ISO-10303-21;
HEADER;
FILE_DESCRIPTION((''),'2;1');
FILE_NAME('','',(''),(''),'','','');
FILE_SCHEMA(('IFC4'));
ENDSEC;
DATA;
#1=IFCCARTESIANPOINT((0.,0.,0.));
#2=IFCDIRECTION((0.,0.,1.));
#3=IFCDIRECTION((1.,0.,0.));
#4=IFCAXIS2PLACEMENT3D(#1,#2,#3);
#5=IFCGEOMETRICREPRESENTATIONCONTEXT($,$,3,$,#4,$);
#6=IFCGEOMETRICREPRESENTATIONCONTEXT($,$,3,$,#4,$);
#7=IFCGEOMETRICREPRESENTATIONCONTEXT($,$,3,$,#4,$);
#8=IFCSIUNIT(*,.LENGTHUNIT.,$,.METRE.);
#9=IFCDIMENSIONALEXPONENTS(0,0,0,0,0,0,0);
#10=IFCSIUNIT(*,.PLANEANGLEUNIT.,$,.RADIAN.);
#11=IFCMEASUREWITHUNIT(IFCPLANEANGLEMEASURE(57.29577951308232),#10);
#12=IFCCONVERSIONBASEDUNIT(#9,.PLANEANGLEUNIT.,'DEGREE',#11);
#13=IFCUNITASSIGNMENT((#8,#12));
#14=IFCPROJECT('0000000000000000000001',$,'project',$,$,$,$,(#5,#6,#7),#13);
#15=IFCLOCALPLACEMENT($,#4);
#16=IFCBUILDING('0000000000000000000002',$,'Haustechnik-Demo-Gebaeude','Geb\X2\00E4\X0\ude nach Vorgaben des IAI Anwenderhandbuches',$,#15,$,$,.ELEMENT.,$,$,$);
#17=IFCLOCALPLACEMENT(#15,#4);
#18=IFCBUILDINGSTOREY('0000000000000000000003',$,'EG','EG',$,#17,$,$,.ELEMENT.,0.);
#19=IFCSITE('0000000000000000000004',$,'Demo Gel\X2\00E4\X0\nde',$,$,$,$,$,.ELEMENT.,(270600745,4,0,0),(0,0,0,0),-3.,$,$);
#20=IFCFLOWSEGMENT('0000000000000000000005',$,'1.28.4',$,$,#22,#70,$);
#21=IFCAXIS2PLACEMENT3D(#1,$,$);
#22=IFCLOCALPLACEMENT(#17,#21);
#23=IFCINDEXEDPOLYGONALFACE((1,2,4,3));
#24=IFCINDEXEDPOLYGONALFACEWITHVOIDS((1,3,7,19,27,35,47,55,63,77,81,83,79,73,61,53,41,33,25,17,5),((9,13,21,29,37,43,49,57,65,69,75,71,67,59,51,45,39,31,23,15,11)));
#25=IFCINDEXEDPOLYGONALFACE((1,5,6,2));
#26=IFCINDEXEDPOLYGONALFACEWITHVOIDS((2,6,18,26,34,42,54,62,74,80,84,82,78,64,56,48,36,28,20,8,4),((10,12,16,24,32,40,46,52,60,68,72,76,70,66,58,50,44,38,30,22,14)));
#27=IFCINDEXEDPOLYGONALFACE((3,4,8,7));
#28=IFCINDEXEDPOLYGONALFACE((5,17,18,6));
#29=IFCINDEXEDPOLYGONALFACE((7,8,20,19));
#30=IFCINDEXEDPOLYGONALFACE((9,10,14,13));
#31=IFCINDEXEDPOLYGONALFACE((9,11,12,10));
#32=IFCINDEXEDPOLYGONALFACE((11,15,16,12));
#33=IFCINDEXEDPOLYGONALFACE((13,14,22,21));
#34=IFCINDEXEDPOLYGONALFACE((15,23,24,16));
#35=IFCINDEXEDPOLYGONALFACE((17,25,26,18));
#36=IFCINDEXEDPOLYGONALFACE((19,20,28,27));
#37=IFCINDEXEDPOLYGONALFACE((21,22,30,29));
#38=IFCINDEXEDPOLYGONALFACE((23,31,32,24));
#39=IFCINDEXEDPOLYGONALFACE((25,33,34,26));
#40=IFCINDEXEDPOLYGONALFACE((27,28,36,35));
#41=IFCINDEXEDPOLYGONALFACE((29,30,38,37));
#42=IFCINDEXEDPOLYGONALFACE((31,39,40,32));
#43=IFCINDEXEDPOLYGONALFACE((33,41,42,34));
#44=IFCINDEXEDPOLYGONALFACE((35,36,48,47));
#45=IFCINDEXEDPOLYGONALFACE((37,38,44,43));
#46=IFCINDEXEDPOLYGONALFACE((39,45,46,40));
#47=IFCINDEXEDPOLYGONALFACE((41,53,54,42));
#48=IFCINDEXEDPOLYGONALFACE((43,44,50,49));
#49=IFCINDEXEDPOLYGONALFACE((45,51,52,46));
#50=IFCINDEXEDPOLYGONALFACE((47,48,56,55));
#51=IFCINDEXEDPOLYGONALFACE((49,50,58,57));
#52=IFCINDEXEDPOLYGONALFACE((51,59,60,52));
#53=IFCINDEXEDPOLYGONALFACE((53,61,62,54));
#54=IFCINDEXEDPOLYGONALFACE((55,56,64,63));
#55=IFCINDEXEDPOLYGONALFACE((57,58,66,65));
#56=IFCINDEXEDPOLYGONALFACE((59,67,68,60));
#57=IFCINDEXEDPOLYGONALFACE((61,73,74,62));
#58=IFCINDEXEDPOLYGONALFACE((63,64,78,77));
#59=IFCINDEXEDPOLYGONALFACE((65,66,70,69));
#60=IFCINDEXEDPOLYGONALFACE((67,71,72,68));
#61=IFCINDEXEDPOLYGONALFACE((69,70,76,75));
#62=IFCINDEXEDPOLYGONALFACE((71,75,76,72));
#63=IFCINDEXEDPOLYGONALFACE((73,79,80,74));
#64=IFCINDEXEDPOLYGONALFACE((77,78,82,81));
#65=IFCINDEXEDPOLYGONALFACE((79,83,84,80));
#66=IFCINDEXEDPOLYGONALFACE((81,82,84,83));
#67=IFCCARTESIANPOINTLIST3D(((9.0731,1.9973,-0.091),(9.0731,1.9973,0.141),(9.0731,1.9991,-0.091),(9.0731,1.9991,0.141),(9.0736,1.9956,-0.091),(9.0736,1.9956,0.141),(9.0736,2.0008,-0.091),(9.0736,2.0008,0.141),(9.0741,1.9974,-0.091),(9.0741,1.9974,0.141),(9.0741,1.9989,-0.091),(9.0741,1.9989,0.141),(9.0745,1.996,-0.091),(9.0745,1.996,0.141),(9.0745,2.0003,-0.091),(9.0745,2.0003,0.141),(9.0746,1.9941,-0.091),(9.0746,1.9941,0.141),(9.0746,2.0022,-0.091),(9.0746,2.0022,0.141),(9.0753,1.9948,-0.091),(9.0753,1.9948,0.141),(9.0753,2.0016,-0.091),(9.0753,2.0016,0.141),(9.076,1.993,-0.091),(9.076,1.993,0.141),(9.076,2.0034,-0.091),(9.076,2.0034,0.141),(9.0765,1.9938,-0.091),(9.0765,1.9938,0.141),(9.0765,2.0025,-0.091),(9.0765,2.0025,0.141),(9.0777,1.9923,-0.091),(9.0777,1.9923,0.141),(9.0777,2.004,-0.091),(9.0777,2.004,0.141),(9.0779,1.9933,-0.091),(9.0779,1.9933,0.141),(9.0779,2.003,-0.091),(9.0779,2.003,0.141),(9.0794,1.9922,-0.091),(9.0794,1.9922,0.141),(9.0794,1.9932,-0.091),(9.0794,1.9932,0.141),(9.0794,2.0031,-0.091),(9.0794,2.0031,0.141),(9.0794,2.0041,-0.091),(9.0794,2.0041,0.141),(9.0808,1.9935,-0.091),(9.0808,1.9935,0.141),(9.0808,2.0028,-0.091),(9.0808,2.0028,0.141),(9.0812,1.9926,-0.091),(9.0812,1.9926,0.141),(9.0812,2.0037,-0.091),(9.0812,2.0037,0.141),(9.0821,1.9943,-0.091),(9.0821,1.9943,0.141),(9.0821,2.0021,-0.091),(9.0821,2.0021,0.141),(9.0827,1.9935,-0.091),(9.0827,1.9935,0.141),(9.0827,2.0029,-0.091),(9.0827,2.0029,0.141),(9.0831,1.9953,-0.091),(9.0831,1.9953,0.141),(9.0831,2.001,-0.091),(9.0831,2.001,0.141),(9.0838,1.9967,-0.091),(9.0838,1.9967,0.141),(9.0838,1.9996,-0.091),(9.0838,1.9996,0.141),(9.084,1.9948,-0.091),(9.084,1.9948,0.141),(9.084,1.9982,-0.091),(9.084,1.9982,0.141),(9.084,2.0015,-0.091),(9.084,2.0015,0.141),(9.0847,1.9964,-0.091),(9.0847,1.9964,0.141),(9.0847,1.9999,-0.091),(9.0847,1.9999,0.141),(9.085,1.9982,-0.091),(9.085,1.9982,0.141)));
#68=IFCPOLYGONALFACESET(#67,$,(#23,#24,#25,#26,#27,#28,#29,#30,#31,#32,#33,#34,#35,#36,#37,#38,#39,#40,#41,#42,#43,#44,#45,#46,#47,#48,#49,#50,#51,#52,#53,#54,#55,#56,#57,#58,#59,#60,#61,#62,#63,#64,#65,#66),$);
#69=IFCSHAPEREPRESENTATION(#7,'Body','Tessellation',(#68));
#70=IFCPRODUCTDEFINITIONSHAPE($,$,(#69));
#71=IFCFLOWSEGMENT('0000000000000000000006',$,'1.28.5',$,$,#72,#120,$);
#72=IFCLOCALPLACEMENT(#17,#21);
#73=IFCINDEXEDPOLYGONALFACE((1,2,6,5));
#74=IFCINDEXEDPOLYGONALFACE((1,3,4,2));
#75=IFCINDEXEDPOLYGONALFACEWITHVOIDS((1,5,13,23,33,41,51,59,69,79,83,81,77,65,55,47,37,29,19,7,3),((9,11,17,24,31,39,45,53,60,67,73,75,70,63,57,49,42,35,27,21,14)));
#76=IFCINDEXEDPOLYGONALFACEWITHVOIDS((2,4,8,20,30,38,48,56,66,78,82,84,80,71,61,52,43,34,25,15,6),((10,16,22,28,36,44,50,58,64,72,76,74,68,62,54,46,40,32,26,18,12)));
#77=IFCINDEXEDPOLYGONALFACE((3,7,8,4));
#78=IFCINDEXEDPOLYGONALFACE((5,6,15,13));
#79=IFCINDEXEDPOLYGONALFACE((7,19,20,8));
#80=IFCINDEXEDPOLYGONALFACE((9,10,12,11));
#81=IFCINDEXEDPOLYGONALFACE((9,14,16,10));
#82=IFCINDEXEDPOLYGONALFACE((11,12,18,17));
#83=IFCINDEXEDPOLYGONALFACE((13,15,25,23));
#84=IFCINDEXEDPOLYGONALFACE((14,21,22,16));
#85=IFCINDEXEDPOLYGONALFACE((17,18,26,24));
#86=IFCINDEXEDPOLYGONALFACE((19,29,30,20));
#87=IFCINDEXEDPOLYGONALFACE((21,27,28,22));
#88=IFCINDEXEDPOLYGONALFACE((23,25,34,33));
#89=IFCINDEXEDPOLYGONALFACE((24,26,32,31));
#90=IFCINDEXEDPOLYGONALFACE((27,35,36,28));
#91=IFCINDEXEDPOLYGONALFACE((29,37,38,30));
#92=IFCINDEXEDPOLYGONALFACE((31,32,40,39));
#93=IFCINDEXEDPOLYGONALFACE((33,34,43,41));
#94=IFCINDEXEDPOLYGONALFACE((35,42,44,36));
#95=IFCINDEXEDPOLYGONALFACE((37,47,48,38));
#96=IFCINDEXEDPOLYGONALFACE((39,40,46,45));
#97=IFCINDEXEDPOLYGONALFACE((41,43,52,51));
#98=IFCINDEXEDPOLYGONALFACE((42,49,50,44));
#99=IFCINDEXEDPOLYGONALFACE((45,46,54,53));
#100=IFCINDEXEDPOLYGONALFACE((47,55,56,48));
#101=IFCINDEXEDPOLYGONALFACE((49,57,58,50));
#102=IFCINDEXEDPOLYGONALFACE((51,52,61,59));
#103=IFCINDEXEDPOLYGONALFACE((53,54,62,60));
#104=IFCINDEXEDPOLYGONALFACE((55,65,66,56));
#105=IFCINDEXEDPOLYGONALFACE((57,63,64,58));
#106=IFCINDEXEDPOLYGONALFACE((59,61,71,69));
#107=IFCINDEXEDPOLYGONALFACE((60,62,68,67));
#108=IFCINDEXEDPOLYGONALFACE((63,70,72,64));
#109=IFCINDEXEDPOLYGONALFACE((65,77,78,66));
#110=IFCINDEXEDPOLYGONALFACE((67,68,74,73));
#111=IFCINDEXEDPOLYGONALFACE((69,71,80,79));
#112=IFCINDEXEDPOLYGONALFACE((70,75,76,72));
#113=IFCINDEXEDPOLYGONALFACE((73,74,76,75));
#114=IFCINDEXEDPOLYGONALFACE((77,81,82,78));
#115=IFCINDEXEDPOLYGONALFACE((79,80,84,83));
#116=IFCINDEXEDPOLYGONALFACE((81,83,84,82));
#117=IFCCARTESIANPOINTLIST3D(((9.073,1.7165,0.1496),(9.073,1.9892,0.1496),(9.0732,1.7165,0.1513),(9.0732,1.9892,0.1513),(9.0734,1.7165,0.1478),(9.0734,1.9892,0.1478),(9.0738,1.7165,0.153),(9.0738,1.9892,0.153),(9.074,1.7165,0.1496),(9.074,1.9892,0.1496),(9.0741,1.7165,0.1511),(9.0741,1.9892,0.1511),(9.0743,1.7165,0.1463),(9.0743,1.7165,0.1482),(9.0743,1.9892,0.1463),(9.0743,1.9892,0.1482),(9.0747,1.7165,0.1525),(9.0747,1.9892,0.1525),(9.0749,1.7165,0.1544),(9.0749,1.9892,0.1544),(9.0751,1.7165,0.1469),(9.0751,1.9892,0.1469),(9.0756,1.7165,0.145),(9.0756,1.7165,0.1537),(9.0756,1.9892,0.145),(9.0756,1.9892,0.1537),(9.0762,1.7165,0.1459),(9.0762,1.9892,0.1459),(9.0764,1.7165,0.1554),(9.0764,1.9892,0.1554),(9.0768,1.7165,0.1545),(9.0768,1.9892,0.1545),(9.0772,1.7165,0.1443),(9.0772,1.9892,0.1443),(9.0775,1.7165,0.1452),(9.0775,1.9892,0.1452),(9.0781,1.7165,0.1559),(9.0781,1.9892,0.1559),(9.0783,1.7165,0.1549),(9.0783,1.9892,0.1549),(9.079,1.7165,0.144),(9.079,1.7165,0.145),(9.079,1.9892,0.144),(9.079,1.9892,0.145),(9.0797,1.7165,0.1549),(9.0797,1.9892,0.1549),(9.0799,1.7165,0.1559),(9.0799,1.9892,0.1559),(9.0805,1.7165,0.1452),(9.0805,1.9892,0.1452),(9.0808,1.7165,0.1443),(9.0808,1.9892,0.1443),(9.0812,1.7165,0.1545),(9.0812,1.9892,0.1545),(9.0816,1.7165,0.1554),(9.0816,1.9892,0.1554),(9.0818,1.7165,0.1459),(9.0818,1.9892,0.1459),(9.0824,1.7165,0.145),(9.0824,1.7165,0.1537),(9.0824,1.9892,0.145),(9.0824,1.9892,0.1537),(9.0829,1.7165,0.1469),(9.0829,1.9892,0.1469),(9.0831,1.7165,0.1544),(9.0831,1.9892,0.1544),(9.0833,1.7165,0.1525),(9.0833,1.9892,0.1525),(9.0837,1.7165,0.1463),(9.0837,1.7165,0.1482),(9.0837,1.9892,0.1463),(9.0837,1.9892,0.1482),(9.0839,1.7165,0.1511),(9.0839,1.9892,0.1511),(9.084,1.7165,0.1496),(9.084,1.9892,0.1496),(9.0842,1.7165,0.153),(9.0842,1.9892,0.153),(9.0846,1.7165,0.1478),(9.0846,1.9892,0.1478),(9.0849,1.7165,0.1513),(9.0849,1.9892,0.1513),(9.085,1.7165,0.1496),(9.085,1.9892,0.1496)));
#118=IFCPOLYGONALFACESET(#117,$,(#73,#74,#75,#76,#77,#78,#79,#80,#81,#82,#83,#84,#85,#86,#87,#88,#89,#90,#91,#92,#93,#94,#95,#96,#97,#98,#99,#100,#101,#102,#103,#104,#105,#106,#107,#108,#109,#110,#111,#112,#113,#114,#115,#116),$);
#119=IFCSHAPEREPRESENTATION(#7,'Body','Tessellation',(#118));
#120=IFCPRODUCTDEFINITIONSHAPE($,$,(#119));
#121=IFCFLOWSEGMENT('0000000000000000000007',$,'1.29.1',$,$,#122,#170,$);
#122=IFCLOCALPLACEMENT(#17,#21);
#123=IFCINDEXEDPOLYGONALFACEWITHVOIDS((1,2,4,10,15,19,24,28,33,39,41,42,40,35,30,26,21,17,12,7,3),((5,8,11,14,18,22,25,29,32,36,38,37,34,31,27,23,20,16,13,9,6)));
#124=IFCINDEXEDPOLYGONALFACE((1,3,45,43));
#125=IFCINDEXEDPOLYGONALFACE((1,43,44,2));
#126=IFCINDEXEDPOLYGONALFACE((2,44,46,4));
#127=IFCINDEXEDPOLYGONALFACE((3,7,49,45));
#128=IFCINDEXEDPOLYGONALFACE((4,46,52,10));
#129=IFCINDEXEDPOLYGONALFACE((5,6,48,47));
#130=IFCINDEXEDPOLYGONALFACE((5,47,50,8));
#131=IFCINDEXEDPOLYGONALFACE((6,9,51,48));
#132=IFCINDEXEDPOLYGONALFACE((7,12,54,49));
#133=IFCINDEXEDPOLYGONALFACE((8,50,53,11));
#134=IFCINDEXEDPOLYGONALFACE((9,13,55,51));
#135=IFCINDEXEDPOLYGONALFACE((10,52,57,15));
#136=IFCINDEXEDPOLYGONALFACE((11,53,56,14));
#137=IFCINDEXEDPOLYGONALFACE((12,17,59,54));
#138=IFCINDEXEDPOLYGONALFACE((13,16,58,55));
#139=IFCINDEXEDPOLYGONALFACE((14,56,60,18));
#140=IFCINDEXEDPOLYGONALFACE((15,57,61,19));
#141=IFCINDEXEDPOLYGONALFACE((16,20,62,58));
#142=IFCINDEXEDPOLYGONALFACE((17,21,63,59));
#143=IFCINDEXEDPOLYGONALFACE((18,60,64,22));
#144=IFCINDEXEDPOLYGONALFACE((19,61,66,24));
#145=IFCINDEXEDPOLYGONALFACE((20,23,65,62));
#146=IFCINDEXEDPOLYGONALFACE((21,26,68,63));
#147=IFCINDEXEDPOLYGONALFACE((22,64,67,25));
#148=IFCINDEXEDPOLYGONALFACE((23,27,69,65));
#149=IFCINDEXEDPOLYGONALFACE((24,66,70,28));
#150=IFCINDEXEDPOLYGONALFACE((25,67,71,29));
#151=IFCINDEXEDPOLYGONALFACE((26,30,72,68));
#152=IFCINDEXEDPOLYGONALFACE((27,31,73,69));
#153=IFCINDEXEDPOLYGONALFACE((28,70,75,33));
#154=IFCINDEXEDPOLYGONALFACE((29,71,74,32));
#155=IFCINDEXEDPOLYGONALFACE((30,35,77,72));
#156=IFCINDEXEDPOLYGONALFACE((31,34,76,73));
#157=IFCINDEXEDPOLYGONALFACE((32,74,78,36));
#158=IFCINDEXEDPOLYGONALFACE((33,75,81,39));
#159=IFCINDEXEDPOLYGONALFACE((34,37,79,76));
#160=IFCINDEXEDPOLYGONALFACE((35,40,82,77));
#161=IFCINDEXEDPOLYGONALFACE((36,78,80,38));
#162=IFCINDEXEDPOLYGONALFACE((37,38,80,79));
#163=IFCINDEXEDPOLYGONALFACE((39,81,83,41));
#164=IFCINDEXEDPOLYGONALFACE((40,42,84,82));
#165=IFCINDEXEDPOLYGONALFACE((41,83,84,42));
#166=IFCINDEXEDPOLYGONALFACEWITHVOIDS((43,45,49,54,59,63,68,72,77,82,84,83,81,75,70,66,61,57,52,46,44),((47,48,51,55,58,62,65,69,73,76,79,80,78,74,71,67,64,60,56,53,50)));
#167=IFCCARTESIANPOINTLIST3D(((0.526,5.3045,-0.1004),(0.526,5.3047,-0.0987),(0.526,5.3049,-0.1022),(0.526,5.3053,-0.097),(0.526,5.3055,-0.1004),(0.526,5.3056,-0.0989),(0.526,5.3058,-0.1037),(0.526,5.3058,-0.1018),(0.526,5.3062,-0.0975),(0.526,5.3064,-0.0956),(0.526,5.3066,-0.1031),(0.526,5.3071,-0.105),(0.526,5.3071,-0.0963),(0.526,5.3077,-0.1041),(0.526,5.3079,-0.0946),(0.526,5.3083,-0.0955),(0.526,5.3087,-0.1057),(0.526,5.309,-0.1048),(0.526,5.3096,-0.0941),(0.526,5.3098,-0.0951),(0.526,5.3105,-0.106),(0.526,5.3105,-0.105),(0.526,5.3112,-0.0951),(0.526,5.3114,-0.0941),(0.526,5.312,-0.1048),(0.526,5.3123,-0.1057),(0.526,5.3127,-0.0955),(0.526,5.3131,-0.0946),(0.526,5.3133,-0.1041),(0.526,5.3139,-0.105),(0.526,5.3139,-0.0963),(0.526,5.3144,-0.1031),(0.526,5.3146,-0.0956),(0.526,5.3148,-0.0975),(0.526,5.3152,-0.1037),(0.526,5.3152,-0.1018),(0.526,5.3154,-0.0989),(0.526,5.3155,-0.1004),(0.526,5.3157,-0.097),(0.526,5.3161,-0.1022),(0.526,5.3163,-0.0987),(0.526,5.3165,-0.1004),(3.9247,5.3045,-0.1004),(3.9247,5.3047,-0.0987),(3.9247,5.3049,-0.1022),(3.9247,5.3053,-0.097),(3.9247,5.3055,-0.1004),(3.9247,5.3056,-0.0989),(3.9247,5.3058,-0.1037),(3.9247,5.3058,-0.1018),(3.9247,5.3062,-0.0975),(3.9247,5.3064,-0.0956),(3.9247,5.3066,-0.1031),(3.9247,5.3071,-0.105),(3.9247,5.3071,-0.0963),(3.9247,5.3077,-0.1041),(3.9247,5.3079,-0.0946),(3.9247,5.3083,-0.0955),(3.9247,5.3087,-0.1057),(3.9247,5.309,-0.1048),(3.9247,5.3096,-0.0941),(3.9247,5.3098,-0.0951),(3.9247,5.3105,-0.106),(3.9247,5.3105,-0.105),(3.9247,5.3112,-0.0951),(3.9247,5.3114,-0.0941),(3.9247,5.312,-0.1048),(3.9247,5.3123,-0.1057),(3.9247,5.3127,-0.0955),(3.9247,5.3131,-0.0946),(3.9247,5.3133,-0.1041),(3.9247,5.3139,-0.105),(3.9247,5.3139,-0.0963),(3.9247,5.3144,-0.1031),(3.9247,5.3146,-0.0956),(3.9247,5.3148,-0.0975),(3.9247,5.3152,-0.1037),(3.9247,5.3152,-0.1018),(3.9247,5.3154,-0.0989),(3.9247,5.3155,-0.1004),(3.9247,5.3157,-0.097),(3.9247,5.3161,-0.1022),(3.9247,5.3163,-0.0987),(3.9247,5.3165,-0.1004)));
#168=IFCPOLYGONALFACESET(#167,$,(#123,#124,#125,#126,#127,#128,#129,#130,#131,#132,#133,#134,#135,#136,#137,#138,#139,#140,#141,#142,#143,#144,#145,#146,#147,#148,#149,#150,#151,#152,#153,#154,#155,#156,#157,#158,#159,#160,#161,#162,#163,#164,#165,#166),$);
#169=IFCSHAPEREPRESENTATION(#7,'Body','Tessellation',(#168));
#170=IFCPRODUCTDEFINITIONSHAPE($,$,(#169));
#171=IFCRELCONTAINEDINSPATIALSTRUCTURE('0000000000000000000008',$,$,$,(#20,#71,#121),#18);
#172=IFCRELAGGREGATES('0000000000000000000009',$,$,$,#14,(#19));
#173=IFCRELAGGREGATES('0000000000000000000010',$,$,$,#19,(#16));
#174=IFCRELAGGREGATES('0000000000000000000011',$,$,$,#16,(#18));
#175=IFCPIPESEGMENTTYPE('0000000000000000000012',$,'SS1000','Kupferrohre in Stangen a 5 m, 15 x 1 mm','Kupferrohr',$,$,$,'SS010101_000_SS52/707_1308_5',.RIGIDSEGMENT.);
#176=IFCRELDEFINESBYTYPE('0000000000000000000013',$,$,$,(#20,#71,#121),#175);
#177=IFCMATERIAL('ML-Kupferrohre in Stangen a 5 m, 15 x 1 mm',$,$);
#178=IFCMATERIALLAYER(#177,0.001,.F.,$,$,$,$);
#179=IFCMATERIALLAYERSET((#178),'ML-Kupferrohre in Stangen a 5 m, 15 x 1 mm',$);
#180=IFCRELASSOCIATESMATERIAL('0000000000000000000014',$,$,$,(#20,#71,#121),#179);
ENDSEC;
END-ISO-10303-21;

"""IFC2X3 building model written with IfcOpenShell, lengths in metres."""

from ifc_helpers import new_model, entity, si_unit, converted_unit, frame, origin_with_axes, origin_2d_with_axis, place, context, project, spatial, hollow_circle, extrude, material, layer, layer_set, layer_usage, type_object, element, save


model = new_model("IFC2X3")

# Units and contexts
context_of_model_1 = context(None, 3, world=origin_with_axes())
context_of_model_2 = context(None, 3, world=origin_with_axes())
context_of_model_3 = context(None, 3, world=origin_with_axes())
ifc_project = project(units=[si_unit("LENGTHUNIT", "METRE"), converted_unit("PLANEANGLEUNIT", "DEGREE", entity("IfcPlaneAngleMeasure", 57.29577951308232), si_unit("PLANEANGLEUNIT", "RADIAN"), dimensions=[0, 0, 0, 0, 0, 0, 0])], contexts=[context_of_model_1, context_of_model_2, context_of_model_3])

# Site, building, storey
site = spatial("IfcSite", under=ifc_project, Name="Demo Gelände", CompositionType="ELEMENT", RefLatitude=(270600745, 4, 0, 0), RefLongitude=(0, 0, 0, 0), RefElevation=-3.0)
building_placement = place(None, origin_with_axes())
building = spatial("IfcBuilding", under=site, at=building_placement, Name="Haustechnik-Demo-Gebaeude", Description="Gebäude nach Vorgaben des IAI Anwenderhandbuches", CompositionType="ELEMENT")
storey_placement = place(building_placement, origin_with_axes())
storey = spatial("IfcBuildingStorey", under=building, at=storey_placement, Name="EG", Description="EG", CompositionType="ELEMENT", Elevation=0.0)

# Flow segments
ifc_material = material(Name="ML-Kupferrohre in Stangen a 5 m, 15 x 1 mm")
ifc_layer = layer(ifc_material, 0.001, ventilated=False)
ifc_layer_set = layer_set([ifc_layer], Name="ML-Kupferrohre in Stangen a 5 m, 15 x 1 mm")
ifc_layer_usage = layer_usage(ifc_layer_set, "AXIS2", "POSITIVE", 0.0)
pipe_segment_type_1 = type_object("IfcPipeSegmentType", Name="SS1000", Description="Kupferrohre in Stangen a 5 m, 15 x 1 mm", ApplicableOccurrence="Kupferrohr", ElementType="SS010101_000_SS52/707_1308_5", PredefinedType="RIGIDSEGMENT")
flow_segment_1_placement = place(storey_placement, frame((9.079, 1.9982, -0.091), z_axis=(0.0, 0.0, 1.0), x_axis=(1.0, 0.0, 0.0)))
element("IfcFlowSegment", 1, at=flow_segment_1_placement, inside=storey, type_object=pipe_segment_type_1, material=ifc_layer_usage, Name="1.28.4", context=context_of_model_3, shape_type="SweptSolid", body=[
    extrude(hollow_circle(Radius=0.006, WallThickness=0.001, at=origin_2d_with_axis()), origin_with_axes(), (0.0, 0.0, 1.0), 0.232),
])
flow_segment_2_placement = place(storey_placement, frame((9.079, 1.9892, 0.15), z_axis=(0.0, -1.0, 0.0), x_axis=(0.0, 0.0, -1.0)))
element("IfcFlowSegment", 2, at=flow_segment_2_placement, inside=storey, type_object=pipe_segment_type_1, material=ifc_layer_usage, Name="1.28.5", context=context_of_model_3, shape_type="SweptSolid", body=[
    extrude(hollow_circle(Radius=0.006, WallThickness=0.001, at=origin_2d_with_axis()), origin_with_axes(), (0.0, 0.0, 1.0), 0.2727),
])
flow_segment_3_placement = place(storey_placement, frame((3.9247, 5.3105, -0.1), z_axis=(-1.0, 0.0, 0.0), x_axis=(0.0, 0.0, -1.0)))
element("IfcFlowSegment", 3, at=flow_segment_3_placement, inside=storey, type_object=pipe_segment_type_1, material=ifc_layer_usage, Name="1.29.1", context=context_of_model_3, shape_type="SweptSolid", body=[
    extrude(hollow_circle(Radius=0.006, WallThickness=0.001, at=origin_2d_with_axis()), origin_with_axes(), (0.0, 0.0, 1.0), 3.3987),
])

save(model, "model.ifc")
